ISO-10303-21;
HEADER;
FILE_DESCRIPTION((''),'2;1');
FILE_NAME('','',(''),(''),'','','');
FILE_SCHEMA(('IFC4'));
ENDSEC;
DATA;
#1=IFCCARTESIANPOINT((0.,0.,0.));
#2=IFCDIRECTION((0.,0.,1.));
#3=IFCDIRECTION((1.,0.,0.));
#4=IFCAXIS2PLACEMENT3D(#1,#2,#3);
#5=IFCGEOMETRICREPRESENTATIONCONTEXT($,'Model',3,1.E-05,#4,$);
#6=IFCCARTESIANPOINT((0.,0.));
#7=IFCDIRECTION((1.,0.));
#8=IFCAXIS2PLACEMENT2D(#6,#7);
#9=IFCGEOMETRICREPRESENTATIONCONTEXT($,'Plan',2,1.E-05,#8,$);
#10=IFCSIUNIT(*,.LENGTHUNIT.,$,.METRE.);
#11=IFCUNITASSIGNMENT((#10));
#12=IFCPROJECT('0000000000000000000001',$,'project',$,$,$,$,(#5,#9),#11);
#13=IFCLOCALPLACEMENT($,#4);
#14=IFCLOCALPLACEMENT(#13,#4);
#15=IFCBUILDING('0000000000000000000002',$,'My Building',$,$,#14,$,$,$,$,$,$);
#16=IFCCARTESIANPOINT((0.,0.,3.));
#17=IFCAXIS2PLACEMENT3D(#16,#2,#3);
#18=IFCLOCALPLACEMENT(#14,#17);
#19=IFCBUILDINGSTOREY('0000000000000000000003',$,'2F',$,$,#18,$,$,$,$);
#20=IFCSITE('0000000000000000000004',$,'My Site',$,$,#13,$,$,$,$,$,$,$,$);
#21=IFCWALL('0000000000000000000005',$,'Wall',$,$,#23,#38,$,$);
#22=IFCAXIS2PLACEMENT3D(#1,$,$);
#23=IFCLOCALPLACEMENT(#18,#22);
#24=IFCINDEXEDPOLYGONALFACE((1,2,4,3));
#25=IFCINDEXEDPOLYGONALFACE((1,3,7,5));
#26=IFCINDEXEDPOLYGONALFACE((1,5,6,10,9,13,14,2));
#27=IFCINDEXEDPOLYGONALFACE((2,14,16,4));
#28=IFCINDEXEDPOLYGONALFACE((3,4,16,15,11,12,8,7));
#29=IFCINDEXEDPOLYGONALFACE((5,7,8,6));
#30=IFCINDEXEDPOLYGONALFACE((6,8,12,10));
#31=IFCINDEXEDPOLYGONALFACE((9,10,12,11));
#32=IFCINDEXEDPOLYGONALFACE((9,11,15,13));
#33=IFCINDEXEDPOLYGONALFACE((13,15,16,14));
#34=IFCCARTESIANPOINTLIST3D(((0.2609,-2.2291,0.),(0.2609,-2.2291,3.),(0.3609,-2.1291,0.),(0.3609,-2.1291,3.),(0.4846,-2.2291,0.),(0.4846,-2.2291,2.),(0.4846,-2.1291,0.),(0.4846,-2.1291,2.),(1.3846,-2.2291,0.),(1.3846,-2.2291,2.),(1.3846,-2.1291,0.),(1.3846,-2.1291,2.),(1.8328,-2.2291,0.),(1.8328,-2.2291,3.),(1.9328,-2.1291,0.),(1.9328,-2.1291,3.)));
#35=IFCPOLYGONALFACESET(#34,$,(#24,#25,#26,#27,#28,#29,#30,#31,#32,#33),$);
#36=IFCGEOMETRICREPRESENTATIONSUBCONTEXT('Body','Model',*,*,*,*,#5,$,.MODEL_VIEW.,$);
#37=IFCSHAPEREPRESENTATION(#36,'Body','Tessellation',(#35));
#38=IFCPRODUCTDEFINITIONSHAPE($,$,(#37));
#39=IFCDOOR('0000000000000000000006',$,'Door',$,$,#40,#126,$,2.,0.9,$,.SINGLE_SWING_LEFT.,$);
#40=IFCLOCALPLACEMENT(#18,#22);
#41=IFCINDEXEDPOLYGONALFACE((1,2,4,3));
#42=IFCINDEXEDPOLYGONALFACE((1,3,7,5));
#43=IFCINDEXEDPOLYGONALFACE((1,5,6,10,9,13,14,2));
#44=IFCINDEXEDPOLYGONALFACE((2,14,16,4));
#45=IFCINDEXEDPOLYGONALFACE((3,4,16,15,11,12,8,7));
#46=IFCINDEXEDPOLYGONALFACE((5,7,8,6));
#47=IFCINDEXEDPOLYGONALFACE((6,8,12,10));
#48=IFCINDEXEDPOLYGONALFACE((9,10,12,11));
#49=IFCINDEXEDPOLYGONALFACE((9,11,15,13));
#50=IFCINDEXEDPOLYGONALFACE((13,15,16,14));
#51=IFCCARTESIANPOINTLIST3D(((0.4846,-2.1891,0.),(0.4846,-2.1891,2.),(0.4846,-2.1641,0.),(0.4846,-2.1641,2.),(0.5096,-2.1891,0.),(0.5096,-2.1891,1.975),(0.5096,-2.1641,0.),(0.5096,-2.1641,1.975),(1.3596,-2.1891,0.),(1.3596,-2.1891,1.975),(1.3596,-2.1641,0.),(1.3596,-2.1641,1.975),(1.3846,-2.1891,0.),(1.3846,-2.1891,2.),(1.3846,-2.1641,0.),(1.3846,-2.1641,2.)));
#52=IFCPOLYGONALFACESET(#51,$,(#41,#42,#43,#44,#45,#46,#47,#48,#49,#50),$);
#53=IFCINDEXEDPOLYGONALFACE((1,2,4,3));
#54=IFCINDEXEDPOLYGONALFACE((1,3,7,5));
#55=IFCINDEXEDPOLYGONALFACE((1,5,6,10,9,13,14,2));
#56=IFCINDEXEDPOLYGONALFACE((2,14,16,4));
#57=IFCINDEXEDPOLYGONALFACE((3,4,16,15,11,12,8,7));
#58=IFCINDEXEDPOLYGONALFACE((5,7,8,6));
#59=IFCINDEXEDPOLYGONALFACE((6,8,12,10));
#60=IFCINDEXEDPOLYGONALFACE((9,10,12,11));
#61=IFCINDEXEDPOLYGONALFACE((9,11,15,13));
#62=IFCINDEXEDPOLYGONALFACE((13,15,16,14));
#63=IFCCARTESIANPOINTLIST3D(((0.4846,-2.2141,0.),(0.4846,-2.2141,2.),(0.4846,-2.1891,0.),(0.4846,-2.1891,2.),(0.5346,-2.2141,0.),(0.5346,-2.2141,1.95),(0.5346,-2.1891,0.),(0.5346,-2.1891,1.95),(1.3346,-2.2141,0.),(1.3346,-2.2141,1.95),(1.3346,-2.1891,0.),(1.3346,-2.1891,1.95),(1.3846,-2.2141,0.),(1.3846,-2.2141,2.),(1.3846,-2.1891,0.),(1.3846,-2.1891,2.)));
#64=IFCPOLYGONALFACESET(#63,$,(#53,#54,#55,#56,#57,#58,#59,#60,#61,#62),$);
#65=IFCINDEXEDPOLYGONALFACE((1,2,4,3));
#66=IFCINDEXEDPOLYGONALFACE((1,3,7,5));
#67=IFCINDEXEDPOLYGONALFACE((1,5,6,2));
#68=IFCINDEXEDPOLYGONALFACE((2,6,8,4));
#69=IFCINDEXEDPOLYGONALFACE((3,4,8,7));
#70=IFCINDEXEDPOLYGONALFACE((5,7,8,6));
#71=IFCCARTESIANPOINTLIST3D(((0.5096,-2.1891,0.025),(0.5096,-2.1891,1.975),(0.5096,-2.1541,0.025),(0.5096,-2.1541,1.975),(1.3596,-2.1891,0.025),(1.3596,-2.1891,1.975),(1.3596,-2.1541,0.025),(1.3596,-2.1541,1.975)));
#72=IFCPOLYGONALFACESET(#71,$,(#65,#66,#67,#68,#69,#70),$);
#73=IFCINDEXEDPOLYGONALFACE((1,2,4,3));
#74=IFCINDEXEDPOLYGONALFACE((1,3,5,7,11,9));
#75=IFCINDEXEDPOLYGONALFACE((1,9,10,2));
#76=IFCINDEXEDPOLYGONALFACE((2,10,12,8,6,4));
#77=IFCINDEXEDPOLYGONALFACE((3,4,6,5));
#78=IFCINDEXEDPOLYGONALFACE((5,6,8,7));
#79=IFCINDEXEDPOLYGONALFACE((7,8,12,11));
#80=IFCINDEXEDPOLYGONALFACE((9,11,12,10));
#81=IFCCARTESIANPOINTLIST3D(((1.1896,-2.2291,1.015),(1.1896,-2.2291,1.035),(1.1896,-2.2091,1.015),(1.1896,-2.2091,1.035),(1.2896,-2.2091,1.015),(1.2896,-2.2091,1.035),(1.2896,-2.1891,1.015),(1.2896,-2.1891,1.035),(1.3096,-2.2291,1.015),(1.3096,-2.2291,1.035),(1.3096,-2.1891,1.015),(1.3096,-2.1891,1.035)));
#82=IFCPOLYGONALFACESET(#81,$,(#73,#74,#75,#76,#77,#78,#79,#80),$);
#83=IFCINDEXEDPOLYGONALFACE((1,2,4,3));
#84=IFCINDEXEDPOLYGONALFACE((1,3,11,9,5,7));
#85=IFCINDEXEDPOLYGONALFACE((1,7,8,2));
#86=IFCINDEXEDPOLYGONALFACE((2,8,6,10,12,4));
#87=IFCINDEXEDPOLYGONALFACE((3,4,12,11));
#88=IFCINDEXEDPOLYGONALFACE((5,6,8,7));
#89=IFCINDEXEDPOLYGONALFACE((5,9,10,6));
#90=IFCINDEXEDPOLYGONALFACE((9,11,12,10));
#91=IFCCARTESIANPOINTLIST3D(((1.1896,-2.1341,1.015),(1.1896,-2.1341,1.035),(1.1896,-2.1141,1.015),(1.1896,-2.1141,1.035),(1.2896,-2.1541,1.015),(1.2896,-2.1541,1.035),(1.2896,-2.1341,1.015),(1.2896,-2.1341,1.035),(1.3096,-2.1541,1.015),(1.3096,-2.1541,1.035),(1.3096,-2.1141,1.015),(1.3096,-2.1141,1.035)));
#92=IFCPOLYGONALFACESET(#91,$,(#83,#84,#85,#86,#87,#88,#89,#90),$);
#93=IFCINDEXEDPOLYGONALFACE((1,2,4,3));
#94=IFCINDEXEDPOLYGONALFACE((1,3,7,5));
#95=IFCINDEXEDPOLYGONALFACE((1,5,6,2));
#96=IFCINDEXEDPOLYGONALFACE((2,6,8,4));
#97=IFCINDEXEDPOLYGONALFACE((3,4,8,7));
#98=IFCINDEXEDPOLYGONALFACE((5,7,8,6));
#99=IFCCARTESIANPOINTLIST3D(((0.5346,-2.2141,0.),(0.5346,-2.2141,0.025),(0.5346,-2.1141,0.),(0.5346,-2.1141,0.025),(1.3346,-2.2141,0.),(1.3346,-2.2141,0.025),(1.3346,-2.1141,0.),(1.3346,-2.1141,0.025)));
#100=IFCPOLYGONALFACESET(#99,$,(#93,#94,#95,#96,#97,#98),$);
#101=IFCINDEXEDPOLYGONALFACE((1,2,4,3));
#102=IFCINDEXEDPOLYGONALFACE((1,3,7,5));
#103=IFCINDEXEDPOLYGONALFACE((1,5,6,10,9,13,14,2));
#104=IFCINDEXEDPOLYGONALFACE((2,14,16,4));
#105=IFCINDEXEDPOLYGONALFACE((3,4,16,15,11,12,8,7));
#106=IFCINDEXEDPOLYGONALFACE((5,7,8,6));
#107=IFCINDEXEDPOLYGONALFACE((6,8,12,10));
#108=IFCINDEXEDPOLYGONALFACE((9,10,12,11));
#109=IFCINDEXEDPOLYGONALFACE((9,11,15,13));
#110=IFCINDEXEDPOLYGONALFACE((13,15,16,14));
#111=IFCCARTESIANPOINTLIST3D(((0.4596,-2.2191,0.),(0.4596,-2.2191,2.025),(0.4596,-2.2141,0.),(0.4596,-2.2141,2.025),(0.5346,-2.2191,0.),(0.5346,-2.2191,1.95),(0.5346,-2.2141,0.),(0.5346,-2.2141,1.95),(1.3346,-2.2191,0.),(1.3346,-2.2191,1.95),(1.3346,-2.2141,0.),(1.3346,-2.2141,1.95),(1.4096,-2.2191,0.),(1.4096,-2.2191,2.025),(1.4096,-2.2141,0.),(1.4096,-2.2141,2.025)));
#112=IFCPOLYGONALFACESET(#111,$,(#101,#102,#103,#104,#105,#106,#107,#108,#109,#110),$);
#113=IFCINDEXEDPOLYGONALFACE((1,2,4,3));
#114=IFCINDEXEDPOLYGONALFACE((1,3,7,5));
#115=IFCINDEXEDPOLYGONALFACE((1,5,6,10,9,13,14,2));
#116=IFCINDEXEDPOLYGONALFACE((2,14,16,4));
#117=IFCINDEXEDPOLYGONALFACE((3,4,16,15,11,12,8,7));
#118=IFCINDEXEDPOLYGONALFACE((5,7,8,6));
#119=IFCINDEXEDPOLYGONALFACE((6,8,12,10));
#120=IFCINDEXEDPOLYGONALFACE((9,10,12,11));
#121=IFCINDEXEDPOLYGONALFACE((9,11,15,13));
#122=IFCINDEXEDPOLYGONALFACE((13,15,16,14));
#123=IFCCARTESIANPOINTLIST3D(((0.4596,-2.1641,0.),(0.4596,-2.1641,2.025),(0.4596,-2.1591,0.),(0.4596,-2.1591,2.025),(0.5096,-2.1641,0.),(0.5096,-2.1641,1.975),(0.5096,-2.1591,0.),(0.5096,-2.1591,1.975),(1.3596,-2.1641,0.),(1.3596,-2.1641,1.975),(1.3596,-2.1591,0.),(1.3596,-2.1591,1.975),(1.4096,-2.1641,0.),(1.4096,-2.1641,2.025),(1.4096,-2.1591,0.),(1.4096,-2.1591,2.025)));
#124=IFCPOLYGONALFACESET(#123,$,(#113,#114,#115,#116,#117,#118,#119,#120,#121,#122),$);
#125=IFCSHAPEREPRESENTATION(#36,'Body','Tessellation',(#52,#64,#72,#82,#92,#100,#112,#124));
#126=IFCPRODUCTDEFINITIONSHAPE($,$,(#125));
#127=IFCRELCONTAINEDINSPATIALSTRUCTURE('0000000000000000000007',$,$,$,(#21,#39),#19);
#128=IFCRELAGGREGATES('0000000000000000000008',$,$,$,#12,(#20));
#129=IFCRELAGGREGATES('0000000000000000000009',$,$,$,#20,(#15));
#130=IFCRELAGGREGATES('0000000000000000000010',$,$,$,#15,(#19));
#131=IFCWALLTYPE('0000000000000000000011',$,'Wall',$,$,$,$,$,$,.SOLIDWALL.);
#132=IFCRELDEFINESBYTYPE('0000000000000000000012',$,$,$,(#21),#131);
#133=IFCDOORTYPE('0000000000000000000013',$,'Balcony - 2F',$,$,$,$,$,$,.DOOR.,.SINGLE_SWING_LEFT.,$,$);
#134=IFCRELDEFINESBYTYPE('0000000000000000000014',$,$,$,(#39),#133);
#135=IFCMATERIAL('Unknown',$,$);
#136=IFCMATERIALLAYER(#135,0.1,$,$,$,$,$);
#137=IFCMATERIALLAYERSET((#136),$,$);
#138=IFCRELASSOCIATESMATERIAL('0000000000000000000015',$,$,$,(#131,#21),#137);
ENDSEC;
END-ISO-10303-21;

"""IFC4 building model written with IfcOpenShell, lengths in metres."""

from ifc_helpers import new_model, entity, si_unit, frame, origin_with_axes, origin_2d_with_axis, place, context, subcontext, project, spatial, line, indexed_curve, outline, extrude, shape, source, transform, mapped, material, layer, layer_set, layer_usage, type_object, type_shapes, element, fill, save


model = new_model("IFC4")

# Units and contexts
model_context = context("Model", 3, precision=1e-05, world=origin_with_axes())
plan_context = context("Plan", 2, precision=1e-05, world=origin_2d_with_axis())
body_context_1 = subcontext(model_context, "Body", "Model", "MODEL_VIEW")
body_context_2 = subcontext(plan_context, "Body", "Plan", "PLAN_VIEW")
ifc_project = project(units=[si_unit("LENGTHUNIT", "METRE")], contexts=[model_context, plan_context])

# Site, building, storey
site_placement = place(None, origin_with_axes())
site = spatial("IfcSite", under=ifc_project, at=site_placement, Name="My Site")
building_placement = place(site_placement, origin_with_axes())
building = spatial("IfcBuilding", under=site, at=building_placement, Name="My Building")
storey_placement = place(building_placement, frame((0.0, 0.0, 3.0), z_axis=(0.0, 0.0, 1.0), x_axis=(1.0, 0.0, 0.0)))
storey = spatial("IfcBuildingStorey", under=building, at=storey_placement, Name="2F")

# Shared definitions
ifc_material = material(Name="Unknown")

# Shared definitions
ifc_layer_1 = layer(ifc_material, 0.1)
ifc_layer_set_1 = layer_set([ifc_layer_1])
wall_type = type_object("IfcWallType", Name="Wall", PredefinedType="SOLIDWALL", material=ifc_layer_set_1)

# Wall, opening, door
ifc_layer_usage_1 = layer_usage(ifc_layer_set_1, "AXIS2", "POSITIVE", 0.0)
wall_1_placement = place(storey_placement, frame((0.2609, -2.2291, 0.0), z_axis=(0.0, 0.0, 1.0), x_axis=(1.0, 0.0, 0.0)))
wall_1 = element("IfcWall", 1, at=wall_1_placement, inside=storey, type_object=wall_type, material=ifc_layer_usage_1, Name="Wall", context=body_context_1, shape_type="SweptSolid", body=[
    extrude(outline(indexed_curve([(0.0, 0.0), (0.1, 0.1), (1.6718, 0.1), (1.5718, 0.0)], segments=[line(1, 2, 3, 4, 1)])), origin_with_axes(), (0.0, 0.0, 1.0), 3.0),
])
shared_shape_1 = source(origin_with_axes(), body_context_1, "Body", "SweptSolid", [
    extrude(outline(indexed_curve([(0.0, 0.0), (0.9, 0.0), (0.9, 2.0), (0.0, 2.0)], segments=[line(1, 2, 3, 4, 1)])), frame((0.0, -0.6, 0.0), z_axis=(0.0, -1.0, 0.0), x_axis=(1.0, 0.0, 0.0)), (0.0, 0.0, -1.0), 1.2),
])
opening_1_placement = place(wall_1_placement, frame((0.2236, 0.015, 0.0), z_axis=(0.0, 0.0, 1.0), x_axis=(1.0, 0.0, 0.0)))
opening_1 = element("IfcOpeningElement", 2, at=opening_1_placement, cuts=wall_1, PredefinedType="OPENING", context=body_context_1, shape_type="MappedRepresentation", body=[
    mapped(shared_shape_1, transform((0.0, 0.0, 0.0), x_axis=(1.0, 0.0, 0.0), y_axis=(0.0, 1.0, 0.0), z_axis=(0.0, 0.0, 1.0), scale=1.0)),
])
door_type_1 = type_object("IfcDoorType", Name="Balcony - 2F", OperationType="SINGLE_SWING_LEFT", PredefinedType="DOOR")
shared_shape_2 = source(origin_with_axes(), body_context_1, "Body", "SweptSolid", [
    extrude(outline(indexed_curve([(0.0, 0.0), (0.0, 2.0), (0.9, 2.0), (0.9, 0.0), (0.875, 0.0), (0.875, 1.975), (0.025, 1.975), (0.025, 0.0)], segments=[line(1, 2, 3, 4, 5, 6, 7, 8, 1)])), frame((0.0, 0.025, 0.0), z_axis=(0.0, -1.0, 0.0), x_axis=(1.0, 0.0, 0.0)), (0.0, 0.0, -1.0), 0.025),
    extrude(outline(indexed_curve([(0.0, 0.0), (0.0, 2.0), (0.9, 2.0), (0.9, 0.0), (0.85, 0.0), (0.85, 1.95), (0.05, 1.95), (0.05, 0.0)], segments=[line(1, 2, 3, 4, 5, 6, 7, 8, 1)])), frame((0.0, 0.0, 0.0), z_axis=(0.0, -1.0, 0.0), x_axis=(1.0, 0.0, 0.0)), (0.0, 0.0, -1.0), 0.025),
    extrude(outline(indexed_curve([(0.0, 0.0), (0.85, 0.0), (0.85, 0.035), (0.0, 0.035)], segments=[line(1, 2, 3, 4, 1)])), frame((0.025, 0.025, 0.025), z_axis=(0.0, 0.0, 1.0), x_axis=(1.0, 0.0, 0.0)), (0.0, 0.0, 1.0), 1.95),
    extrude(outline(indexed_curve([(0.0, 0.0), (0.0, -0.04), (-0.12, -0.04), (-0.12, -0.02), (-0.02, -0.02), (-0.02, 0.0)], segments=[line(1, 2, 3, 4, 5, 6, 1)])), frame((0.825, 0.025, 1.015), z_axis=(0.0, 0.0, 1.0), x_axis=(1.0, 0.0, 0.0)), (0.0, 0.0, 1.0), 0.02),
    extrude(outline(indexed_curve([(0.0, 0.0), (0.0, 0.04), (-0.12, 0.04), (-0.12, 0.02), (-0.02, 0.02), (-0.02, 0.0)], segments=[line(1, 2, 3, 4, 5, 6, 1)])), frame((0.825, 0.06, 1.015), z_axis=(0.0, 0.0, 1.0), x_axis=(1.0, 0.0, 0.0)), (0.0, 0.0, 1.0), 0.02),
    extrude(outline(indexed_curve([(0.0, 0.0), (0.8, 0.0), (0.8, 0.1), (0.0, 0.1)], segments=[line(1, 2, 3, 4, 1)])), frame((0.05, 0.0, 0.0), z_axis=(0.0, 0.0, 1.0), x_axis=(1.0, 0.0, 0.0)), (0.0, 0.0, 1.0), 0.025),
    extrude(outline(indexed_curve([(0.0, 0.0), (0.0, 2.025), (0.95, 2.025), (0.95, 0.0), (0.875, 0.0), (0.875, 1.95), (0.075, 1.95), (0.075, 0.0)], segments=[line(1, 2, 3, 4, 5, 6, 7, 8, 1)])), frame((-0.025, -0.005, 0.0), z_axis=(0.0, -1.0, 0.0), x_axis=(1.0, 0.0, 0.0)), (0.0, 0.0, -1.0), 0.005),
    extrude(outline(indexed_curve([(0.0, 0.0), (0.0, 2.025), (0.95, 2.025), (0.95, 0.0), (0.9, 0.0), (0.9, 1.975), (0.05, 1.975), (0.05, 0.0)], segments=[line(1, 2, 3, 4, 5, 6, 7, 8, 1)])), frame((-0.025, 0.05, 0.0), z_axis=(0.0, -1.0, 0.0), x_axis=(1.0, 0.0, 0.0)), (0.0, 0.0, -1.0), 0.005),
])
shared_shape_3 = source(origin_with_axes(), body_context_2, "Body", "Curve2D", [
    entity("IfcIndexedPolyCurve", entity("IfcCartesianPointList2D", [[0.0, 0.0], [0.0, 0.05], [0.025, 0.05], [0.025, 0.025], [0.05, 0.025], [0.05, 0.0]]), [entity("IfcLineIndex", [1, 2, 3, 4, 5, 6, 1])]),
    entity("IfcIndexedPolyCurve", entity("IfcCartesianPointList2D", [[0.9, 0.0], [0.9, 0.05], [0.875, 0.05], [0.875, 0.025], [0.85, 0.025], [0.85, 0.0]]), [entity("IfcLineIndex", [1, 2, 3, 4, 5, 6, 1])]),
    entity("IfcTrimmedCurve", entity("IfcEllipse", entity("IfcAxis2Placement2D", entity("IfcCartesianPoint", [0.06, 0.05]), entity("IfcDirection", [1.0, 0.0])), 0.815, 0.85), [entity("IfcCartesianPoint", [0.875, 0.05])], [entity("IfcCartesianPoint", [0.06, 0.9])], True, "CARTESIAN"),
    entity("IfcIndexedPolyCurve", entity("IfcCartesianPointList2D", [[0.025, 0.05], [0.06, 0.05], [0.06, 0.9], [0.025, 0.9]]), [entity("IfcLineIndex", [1, 2, 3, 4, 1])]),
])
type_shapes(door_type_1, [shared_shape_2, shared_shape_3])
door_1_placement = place(opening_1_placement, frame((0.0, 0.0, 0.0), z_axis=(0.0, 0.0, 1.0), x_axis=(1.0, 0.0, 0.0)))
door_1 = element("IfcDoor", 3, at=door_1_placement, inside=storey, type_object=door_type_1, Name="Door", OperationType="SINGLE_SWING_LEFT", OverallHeight=2.0, OverallWidth=0.9, shapes=[
    shape(body_context_1, "Body", "MappedRepresentation", [mapped(shared_shape_2, transform((0.0, 0.0, 0.0), x_axis=(1.0, 0.0, 0.0), y_axis=(0.0, 1.0, 0.0), z_axis=(0.0, 0.0, 1.0), scale=1.0))]),
    shape(body_context_2, "Body", "MappedRepresentation", [mapped(shared_shape_3, transform((0.0, 0.0, 0.0), x_axis=(1.0, 0.0, 0.0), y_axis=(0.0, 1.0, 0.0), z_axis=(0.0, 0.0, 1.0), scale=1.0))]),
])
fill(opening_1, door_1)

save(model, "model.ifc")
